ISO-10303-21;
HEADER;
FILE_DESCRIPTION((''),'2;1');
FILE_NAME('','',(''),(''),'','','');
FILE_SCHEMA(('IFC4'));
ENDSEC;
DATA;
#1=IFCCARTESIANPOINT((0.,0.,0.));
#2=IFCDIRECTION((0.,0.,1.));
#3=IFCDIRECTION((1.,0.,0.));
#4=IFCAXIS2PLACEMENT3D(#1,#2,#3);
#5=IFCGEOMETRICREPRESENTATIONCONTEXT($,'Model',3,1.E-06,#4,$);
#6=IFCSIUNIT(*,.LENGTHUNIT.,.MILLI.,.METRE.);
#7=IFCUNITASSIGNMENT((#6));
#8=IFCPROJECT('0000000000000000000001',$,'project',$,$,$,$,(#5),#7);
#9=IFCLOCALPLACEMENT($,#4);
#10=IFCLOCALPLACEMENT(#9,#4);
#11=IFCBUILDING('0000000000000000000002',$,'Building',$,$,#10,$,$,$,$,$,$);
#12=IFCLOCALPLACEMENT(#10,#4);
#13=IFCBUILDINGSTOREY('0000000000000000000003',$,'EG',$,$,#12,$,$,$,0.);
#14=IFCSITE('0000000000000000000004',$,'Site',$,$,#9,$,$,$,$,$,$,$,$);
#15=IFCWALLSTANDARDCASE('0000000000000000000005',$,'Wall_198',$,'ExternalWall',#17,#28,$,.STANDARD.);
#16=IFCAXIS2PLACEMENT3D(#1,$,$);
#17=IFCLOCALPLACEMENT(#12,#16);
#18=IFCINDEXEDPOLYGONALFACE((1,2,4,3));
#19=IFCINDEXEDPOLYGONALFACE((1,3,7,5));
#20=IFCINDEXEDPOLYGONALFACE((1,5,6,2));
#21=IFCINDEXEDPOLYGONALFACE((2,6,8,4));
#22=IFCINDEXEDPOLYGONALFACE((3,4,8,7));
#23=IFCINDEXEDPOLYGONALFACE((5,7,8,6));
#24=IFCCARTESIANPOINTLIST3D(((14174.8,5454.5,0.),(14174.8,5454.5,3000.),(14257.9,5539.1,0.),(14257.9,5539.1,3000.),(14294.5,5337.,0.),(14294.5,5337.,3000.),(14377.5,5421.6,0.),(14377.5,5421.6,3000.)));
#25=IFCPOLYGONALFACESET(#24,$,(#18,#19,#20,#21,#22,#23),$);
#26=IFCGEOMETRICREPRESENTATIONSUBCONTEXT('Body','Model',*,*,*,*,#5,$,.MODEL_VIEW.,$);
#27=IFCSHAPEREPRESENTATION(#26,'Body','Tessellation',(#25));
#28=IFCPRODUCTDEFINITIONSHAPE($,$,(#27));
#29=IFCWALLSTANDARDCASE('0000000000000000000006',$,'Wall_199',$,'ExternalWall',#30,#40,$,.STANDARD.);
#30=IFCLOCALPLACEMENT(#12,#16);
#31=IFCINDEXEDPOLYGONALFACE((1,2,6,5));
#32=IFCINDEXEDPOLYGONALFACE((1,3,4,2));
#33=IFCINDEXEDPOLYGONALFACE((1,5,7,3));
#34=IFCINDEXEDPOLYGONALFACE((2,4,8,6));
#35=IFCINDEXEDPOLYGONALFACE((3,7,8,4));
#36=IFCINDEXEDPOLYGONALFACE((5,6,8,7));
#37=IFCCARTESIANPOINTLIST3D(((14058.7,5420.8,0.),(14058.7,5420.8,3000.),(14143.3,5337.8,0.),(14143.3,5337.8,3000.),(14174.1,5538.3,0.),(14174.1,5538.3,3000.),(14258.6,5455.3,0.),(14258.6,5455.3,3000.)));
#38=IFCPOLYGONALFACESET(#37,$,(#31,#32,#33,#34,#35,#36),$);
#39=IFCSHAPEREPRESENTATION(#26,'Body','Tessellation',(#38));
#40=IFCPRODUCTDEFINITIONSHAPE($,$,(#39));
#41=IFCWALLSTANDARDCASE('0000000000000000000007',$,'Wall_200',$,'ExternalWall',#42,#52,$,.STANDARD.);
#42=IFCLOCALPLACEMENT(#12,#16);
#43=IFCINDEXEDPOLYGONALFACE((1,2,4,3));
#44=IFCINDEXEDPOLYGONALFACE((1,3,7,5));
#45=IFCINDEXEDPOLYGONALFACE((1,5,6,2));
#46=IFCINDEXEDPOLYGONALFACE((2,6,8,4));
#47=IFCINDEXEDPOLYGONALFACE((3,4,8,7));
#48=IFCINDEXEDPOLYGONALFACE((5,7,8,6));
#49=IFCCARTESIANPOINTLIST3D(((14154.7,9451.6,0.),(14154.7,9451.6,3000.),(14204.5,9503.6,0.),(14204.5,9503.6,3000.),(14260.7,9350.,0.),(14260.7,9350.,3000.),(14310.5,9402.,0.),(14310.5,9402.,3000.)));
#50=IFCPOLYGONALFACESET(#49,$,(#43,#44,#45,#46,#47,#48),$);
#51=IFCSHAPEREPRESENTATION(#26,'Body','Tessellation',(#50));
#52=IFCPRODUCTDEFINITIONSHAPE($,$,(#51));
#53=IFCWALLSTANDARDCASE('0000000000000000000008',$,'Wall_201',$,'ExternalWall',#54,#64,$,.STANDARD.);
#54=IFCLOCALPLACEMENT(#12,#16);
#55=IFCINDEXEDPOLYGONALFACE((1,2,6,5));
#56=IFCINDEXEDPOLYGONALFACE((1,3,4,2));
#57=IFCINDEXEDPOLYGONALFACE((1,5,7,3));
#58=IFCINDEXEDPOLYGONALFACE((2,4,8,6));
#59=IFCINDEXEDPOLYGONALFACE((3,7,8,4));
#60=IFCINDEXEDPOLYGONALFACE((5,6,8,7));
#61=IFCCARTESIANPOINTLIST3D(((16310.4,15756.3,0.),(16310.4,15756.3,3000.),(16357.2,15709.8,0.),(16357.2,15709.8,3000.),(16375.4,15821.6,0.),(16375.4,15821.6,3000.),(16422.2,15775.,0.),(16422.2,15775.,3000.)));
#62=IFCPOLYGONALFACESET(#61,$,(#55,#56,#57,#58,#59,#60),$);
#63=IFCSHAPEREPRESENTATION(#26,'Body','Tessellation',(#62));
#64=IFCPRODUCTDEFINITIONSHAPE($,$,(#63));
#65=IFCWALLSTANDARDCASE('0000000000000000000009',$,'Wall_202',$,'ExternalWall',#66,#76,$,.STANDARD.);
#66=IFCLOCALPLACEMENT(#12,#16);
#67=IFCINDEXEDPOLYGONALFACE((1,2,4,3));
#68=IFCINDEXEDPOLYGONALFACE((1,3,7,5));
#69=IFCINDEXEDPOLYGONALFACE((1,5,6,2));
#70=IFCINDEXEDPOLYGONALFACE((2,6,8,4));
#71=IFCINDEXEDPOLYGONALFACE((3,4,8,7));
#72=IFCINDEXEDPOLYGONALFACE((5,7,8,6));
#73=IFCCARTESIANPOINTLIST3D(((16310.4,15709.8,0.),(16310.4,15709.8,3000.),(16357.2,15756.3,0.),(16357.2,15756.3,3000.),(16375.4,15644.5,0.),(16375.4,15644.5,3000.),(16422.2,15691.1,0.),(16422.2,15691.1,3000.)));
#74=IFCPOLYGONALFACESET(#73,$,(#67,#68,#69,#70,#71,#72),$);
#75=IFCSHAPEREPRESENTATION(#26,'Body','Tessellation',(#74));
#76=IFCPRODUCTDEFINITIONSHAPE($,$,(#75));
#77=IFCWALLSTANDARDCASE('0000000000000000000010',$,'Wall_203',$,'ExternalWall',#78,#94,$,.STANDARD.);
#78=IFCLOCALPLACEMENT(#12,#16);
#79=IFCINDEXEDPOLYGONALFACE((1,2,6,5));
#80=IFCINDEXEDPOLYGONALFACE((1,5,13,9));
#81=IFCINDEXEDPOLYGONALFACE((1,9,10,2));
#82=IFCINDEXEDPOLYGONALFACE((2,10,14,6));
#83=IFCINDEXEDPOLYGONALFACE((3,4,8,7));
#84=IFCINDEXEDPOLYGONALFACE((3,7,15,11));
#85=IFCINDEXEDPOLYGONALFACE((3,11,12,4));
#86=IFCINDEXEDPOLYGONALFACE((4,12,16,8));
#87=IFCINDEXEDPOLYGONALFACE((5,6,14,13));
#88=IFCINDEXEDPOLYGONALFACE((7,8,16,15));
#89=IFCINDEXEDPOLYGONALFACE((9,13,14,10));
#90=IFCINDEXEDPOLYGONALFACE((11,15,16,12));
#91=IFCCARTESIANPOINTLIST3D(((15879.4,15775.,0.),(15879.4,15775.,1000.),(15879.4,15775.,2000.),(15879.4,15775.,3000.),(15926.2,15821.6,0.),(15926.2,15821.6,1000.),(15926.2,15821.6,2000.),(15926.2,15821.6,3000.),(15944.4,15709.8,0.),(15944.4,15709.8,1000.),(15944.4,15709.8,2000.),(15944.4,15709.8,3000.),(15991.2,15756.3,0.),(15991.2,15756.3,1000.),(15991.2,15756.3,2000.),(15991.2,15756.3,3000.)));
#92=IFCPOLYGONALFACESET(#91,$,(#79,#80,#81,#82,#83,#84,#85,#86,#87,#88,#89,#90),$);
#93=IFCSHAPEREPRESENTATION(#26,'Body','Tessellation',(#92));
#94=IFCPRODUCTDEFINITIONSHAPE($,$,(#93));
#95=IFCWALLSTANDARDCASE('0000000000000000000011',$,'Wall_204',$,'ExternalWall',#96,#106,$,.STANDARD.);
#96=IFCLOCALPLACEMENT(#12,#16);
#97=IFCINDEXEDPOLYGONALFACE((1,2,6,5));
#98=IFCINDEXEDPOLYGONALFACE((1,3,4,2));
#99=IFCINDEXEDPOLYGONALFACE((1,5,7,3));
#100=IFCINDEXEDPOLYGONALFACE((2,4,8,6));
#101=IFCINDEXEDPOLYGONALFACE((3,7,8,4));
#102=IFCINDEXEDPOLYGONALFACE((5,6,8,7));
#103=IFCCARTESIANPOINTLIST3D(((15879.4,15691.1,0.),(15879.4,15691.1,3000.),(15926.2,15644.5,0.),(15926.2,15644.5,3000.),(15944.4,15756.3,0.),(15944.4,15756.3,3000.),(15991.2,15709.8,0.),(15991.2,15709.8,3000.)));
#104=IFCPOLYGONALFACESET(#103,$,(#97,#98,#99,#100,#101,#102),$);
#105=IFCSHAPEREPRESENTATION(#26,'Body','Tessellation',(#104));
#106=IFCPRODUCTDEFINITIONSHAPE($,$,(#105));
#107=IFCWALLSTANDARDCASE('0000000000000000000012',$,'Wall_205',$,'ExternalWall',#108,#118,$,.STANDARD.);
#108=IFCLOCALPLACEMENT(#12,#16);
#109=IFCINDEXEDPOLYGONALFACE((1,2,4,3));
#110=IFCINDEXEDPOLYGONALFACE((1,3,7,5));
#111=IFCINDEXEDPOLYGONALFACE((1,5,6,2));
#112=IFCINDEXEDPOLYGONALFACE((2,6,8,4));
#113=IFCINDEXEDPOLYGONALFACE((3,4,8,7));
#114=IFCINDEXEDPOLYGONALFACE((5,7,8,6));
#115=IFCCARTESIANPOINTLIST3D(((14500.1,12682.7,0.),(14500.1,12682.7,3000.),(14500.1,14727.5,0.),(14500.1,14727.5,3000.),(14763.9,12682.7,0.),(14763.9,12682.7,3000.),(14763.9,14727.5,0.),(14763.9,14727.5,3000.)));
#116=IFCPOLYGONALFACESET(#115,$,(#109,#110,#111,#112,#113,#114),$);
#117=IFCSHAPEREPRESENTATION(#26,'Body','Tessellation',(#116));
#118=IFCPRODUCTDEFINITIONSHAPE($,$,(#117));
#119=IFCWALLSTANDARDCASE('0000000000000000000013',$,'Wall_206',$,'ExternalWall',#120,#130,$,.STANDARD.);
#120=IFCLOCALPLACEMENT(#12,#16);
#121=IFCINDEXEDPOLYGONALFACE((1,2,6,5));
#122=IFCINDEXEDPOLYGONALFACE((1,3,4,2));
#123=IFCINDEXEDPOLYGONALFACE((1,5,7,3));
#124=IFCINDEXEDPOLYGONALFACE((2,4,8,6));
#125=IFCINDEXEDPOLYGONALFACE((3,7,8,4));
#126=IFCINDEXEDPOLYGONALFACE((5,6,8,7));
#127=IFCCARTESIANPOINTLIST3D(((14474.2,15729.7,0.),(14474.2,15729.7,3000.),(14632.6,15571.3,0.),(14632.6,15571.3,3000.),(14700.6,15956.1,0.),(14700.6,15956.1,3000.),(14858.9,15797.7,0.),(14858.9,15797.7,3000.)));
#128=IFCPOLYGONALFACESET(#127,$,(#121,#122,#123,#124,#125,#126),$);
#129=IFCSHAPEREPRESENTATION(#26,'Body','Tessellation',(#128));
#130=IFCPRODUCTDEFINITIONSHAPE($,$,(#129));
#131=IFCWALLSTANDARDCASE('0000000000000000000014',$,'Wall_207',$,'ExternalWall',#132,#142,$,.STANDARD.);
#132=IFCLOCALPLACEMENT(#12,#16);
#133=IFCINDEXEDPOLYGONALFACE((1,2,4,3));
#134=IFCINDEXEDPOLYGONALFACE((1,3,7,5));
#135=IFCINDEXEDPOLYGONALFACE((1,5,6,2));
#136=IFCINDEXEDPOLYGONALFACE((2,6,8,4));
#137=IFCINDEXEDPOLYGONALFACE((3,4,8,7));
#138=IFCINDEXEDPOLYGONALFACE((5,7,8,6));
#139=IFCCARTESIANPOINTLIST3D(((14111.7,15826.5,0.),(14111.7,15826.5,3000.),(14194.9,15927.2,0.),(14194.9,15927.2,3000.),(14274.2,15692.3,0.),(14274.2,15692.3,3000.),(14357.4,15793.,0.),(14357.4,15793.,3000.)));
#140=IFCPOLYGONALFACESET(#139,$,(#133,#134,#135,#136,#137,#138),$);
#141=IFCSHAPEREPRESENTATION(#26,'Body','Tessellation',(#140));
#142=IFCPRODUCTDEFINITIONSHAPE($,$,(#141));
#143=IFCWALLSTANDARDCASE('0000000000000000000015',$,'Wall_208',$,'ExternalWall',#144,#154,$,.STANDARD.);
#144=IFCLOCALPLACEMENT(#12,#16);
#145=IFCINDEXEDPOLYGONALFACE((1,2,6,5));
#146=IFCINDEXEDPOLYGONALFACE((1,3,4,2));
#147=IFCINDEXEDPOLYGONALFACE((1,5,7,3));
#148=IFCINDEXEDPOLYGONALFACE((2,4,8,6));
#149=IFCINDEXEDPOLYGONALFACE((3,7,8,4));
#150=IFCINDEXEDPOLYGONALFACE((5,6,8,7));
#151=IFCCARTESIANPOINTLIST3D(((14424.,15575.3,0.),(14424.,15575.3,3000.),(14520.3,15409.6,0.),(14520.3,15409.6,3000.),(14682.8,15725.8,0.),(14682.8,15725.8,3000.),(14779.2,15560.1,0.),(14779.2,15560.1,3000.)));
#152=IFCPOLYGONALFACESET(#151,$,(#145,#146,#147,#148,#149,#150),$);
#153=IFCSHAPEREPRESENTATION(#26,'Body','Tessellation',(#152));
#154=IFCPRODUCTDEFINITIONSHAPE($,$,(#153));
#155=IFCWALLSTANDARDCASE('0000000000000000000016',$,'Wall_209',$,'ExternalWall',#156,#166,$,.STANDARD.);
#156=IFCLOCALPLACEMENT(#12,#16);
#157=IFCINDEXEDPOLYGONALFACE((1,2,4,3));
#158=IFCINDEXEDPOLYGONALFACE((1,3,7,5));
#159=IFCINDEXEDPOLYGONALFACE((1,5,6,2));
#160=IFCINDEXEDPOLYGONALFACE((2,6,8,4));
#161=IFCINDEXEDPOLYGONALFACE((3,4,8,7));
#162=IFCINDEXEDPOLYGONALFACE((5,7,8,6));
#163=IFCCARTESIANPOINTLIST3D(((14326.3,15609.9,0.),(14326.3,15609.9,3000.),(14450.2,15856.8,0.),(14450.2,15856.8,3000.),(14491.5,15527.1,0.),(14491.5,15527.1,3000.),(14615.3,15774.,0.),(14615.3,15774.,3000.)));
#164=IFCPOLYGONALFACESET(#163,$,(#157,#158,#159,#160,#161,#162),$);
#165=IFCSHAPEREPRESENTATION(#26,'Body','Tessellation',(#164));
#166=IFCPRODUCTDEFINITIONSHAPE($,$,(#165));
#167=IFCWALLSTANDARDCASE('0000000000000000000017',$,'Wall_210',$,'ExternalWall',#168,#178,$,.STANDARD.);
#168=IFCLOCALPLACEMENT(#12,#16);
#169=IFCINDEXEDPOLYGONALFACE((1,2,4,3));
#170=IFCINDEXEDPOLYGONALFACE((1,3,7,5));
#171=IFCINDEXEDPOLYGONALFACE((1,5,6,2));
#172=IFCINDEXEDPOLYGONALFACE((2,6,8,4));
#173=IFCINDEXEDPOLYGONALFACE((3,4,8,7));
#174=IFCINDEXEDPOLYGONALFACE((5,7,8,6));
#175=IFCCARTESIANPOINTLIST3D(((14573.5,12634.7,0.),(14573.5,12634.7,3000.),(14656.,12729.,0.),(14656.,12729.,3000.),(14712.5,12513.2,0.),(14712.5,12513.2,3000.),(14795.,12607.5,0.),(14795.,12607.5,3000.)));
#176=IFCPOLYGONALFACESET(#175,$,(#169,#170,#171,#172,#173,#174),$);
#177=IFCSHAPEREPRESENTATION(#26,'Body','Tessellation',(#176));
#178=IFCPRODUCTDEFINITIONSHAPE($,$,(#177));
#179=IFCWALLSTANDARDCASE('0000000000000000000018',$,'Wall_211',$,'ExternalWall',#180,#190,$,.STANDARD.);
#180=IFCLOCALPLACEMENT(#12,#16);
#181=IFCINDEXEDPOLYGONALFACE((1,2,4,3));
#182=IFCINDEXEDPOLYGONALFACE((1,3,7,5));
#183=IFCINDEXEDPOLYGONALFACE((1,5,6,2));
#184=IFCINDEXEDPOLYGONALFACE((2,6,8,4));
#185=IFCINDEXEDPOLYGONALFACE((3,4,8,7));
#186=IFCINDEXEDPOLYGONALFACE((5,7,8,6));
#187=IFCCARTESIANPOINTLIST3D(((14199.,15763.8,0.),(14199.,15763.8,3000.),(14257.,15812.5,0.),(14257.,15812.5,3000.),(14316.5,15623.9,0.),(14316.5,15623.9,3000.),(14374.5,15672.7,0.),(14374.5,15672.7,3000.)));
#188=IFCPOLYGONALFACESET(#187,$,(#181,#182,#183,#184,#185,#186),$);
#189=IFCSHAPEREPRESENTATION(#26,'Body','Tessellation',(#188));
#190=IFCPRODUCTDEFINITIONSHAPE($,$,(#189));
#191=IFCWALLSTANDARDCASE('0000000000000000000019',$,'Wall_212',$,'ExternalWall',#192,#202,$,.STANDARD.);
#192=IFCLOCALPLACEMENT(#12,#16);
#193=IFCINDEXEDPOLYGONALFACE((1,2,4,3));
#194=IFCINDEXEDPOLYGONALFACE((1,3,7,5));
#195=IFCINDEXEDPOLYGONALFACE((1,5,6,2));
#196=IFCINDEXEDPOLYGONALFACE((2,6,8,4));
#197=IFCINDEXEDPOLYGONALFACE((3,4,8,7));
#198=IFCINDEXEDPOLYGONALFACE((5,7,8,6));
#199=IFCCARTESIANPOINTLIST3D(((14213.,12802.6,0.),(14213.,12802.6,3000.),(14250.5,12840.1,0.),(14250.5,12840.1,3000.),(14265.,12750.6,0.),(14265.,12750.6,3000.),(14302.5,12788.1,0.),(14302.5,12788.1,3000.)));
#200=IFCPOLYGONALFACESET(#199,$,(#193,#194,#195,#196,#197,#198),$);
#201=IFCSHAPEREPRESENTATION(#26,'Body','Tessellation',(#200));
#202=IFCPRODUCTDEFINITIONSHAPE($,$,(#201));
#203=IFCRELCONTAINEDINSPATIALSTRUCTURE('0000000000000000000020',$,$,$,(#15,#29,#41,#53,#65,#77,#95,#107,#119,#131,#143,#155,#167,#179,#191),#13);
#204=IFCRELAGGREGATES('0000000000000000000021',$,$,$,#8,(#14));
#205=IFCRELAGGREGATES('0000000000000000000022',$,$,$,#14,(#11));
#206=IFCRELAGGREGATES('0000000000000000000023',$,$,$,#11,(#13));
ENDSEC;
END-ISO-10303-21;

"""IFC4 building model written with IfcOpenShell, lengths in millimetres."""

from ifc_helpers import new_model, si_unit, frame, origin_with_axes, place, context, subcontext, project, spatial, rectangle, extrude, element, save


model = new_model("IFC4")

# Units and contexts
model_context = context("Model", 3, precision=1e-06, world=origin_with_axes())
body_context = subcontext(model_context, "Body", "Model", "MODEL_VIEW")
ifc_project = project(units=[si_unit("LENGTHUNIT", "METRE", prefix="MILLI")], contexts=[model_context])

# Site, building, storey
site_placement = place(None, origin_with_axes())
site = spatial("IfcSite", under=ifc_project, at=site_placement, Name="Site")
building_placement = place(site_placement, origin_with_axes())
building = spatial("IfcBuilding", under=site, at=building_placement, Name="Building")
storey_placement = place(building_placement, origin_with_axes())
storey = spatial("IfcBuildingStorey", under=building, at=storey_placement, Name="EG", Elevation=0.0)

# Walls
wall_1_placement = place(storey_placement, origin_with_axes())
element("IfcWallStandardCase", 1, at=wall_1_placement, inside=storey, Name="Wall_198", ObjectType="ExternalWall", PredefinedType="STANDARD", context=body_context, shape_type="SweptSolid", body=[
    extrude(rectangle(XDim=167.7, YDim=118.5), frame((14276.2, 5438.0, 0.0), z_axis=(0.0, 0.0, 1.0), x_axis=(0.713548, -0.700607, 0.0)), (0.0, 0.0, 1.0), 3000.0),
])
wall_2_placement = place(storey_placement, origin_with_axes())
element("IfcWallStandardCase", 2, at=wall_2_placement, inside=storey, Name="Wall_199", ObjectType="ExternalWall", PredefinedType="STANDARD", context=body_context, shape_type="SweptSolid", body=[
    extrude(rectangle(XDim=164.6, YDim=118.5), frame((14158.7, 5438.0, 0.0), z_axis=(0.0, 0.0, 1.0), x_axis=(-0.700507, -0.713645, 0.0)), (0.0, 0.0, 1.0), 3000.0),
])
wall_3_placement = place(storey_placement, origin_with_axes())
element("IfcWallStandardCase", 3, at=wall_3_placement, inside=storey, Name="Wall_200", ObjectType="ExternalWall", PredefinedType="STANDARD", context=body_context, shape_type="SweptSolid", body=[
    extrude(rectangle(XDim=72.0, YDim=146.8), frame((14232.6, 9426.8, 0.0), z_axis=(0.0, 0.0, 1.0), x_axis=(0.69193, 0.721964, 0.0)), (0.0, 0.0, 1.0), 3000.0),
])
wall_4_placement = place(storey_placement, origin_with_axes())
element("IfcWallStandardCase", 4, at=wall_4_placement, inside=storey, Name="Wall_201", ObjectType="ExternalWall", PredefinedType="STANDARD", context=body_context, shape_type="SweptSolid", body=[
    extrude(rectangle(XDim=92.1, YDim=66.0), frame((16366.3, 15765.7, 0.0), z_axis=(0.0, 0.0, 1.0), x_axis=(0.705748, 0.708463, 0.0)), (0.0, 0.0, 1.0), 3000.0),
])
wall_5_placement = place(storey_placement, origin_with_axes())
element("IfcWallStandardCase", 5, at=wall_5_placement, inside=storey, Name="Wall_202", ObjectType="ExternalWall", PredefinedType="STANDARD", context=body_context, shape_type="SweptSolid", body=[
    extrude(rectangle(XDim=92.1, YDim=66.0), frame((16366.3, 15700.4, 0.0), z_axis=(0.0, 0.0, 1.0), x_axis=(0.705748, -0.708463, 0.0)), (0.0, 0.0, 1.0), 3000.0),
])

# Wall, opening
wall_6_placement = place(storey_placement, origin_with_axes())
wall_6 = element("IfcWallStandardCase", 6, at=wall_6_placement, inside=storey, Name="Wall_203", ObjectType="ExternalWall", PredefinedType="STANDARD", context=body_context, shape_type="SweptSolid", body=[
    extrude(rectangle(XDim=92.1, YDim=66.0), frame((15935.3, 15765.7, 0.0), z_axis=(0.0, 0.0, 1.0), x_axis=(-0.705748, 0.708463, 0.0)), (0.0, 0.0, 1.0), 3000.0),
])
opening_placement = place(wall_6_placement, origin_with_axes())
element("IfcOpeningElement", 7, at=opening_placement, inside=storey, cuts=wall_6, context=body_context, shape_type="SweptSolid", body=[
    extrude(rectangle(XDim=600.0, YDim=66.0), frame((15922.4, 15778.6, 1000.0), z_axis=(0.0, 0.0, 1.0), x_axis=(-0.705748, 0.708463, 0.0)), (0.0, 0.0, 1.0), 1000.0),
])

# Walls
wall_7_placement = place(storey_placement, origin_with_axes())
element("IfcWallStandardCase", 8, at=wall_7_placement, inside=storey, Name="Wall_204", ObjectType="ExternalWall", PredefinedType="STANDARD", context=body_context, shape_type="SweptSolid", body=[
    extrude(rectangle(XDim=92.1, YDim=66.0), frame((15935.3, 15700.4, 0.0), z_axis=(0.0, 0.0, 1.0), x_axis=(-0.705748, -0.708463, 0.0)), (0.0, 0.0, 1.0), 3000.0),
])
wall_8_placement = place(storey_placement, origin_with_axes())
element("IfcWallStandardCase", 9, at=wall_8_placement, inside=storey, Name="Wall_205", ObjectType="ExternalWall", PredefinedType="STANDARD", context=body_context, shape_type="SweptSolid", body=[
    extrude(rectangle(XDim=2044.8, YDim=263.7), frame((14632.0, 13705.1, 0.0), z_axis=(0.0, 0.0, 1.0), x_axis=(0.0, -1.0, 0.0)), (0.0, 0.0, 1.0), 3000.0),
])
wall_9_placement = place(storey_placement, origin_with_axes())
element("IfcWallStandardCase", 10, at=wall_9_placement, inside=storey, Name="Wall_206", ObjectType="ExternalWall", PredefinedType="STANDARD", context=body_context, shape_type="SweptSolid", body=[
    extrude(rectangle(XDim=320.1, YDim=224.0), frame((14666.6, 15763.7, 0.0), z_axis=(0.0, 0.0, 1.0), x_axis=(0.707107, 0.707107, 0.0)), (0.0, 0.0, 1.0), 3000.0),
])
wall_10_placement = place(storey_placement, origin_with_axes())
element("IfcWallStandardCase", 11, at=wall_10_placement, inside=storey, Name="Wall_207", ObjectType="ExternalWall", PredefinedType="STANDARD", context=body_context, shape_type="SweptSolid", body=[
    extrude(rectangle(XDim=210.8, YDim=130.6), frame((14234.5, 15809.7, 0.0), z_axis=(0.0, 0.0, 1.0), x_axis=(-0.770936, 0.636912, 0.0)), (0.0, 0.0, 1.0), 3000.0),
])
wall_11_placement = place(storey_placement, origin_with_axes())
element("IfcWallStandardCase", 12, at=wall_11_placement, inside=storey, Name="Wall_208", ObjectType="ExternalWall", PredefinedType="STANDARD", context=body_context, shape_type="SweptSolid", body=[
    extrude(rectangle(XDim=191.6, YDim=299.4), frame((14601.6, 15567.7, 0.0), z_axis=(0.0, 0.0, 1.0), x_axis=(0.502681, -0.864472, 0.0)), (0.0, 0.0, 1.0), 3000.0),
])
wall_12_placement = place(storey_placement, origin_with_axes())
element("IfcWallStandardCase", 13, at=wall_12_placement, inside=storey, Name="Wall_209", ObjectType="ExternalWall", PredefinedType="STANDARD", context=body_context, shape_type="SweptSolid", body=[
    extrude(rectangle(XDim=184.8, YDim=276.2), frame((14470.8, 15691.9, 0.0), z_axis=(0.0, 0.0, 1.0), x_axis=(-0.893885, 0.448296, 0.0)), (0.0, 0.0, 1.0), 3000.0),
])
wall_13_placement = place(storey_placement, origin_with_axes())
element("IfcWallStandardCase", 14, at=wall_13_placement, inside=storey, Name="Wall_210", ObjectType="ExternalWall", PredefinedType="STANDARD", context=body_context, shape_type="SweptSolid", body=[
    extrude(rectangle(XDim=184.6, YDim=125.3), frame((14684.3, 12621.1, 0.0), z_axis=(0.0, 0.0, 1.0), x_axis=(0.752912, -0.658121, 0.0)), (0.0, 0.0, 1.0), 3000.0),
])
wall_14_placement = place(storey_placement, origin_with_axes())
element("IfcWallStandardCase", 15, at=wall_14_placement, inside=storey, Name="Wall_211", ObjectType="ExternalWall", PredefinedType="STANDARD", context=body_context, shape_type="SweptSolid", body=[
    extrude(rectangle(XDim=75.8, YDim=182.7), frame((14286.8, 15718.2, 0.0), z_axis=(0.0, 0.0, 1.0), x_axis=(-0.76551, -0.643424, 0.0)), (0.0, 0.0, 1.0), 3000.0),
])
wall_15_placement = place(storey_placement, origin_with_axes())
element("IfcWallStandardCase", 16, at=wall_15_placement, inside=storey, Name="Wall_212", ObjectType="ExternalWall", PredefinedType="STANDARD", context=body_context, shape_type="SweptSolid", body=[
    extrude(rectangle(XDim=73.5, YDim=53.0), frame((14257.8, 12795.4, 0.0), z_axis=(0.0, 0.0, 1.0), x_axis=(-0.707107, 0.707107, 0.0)), (0.0, 0.0, 1.0), 3000.0),
])

save(model, "model.ifc")
